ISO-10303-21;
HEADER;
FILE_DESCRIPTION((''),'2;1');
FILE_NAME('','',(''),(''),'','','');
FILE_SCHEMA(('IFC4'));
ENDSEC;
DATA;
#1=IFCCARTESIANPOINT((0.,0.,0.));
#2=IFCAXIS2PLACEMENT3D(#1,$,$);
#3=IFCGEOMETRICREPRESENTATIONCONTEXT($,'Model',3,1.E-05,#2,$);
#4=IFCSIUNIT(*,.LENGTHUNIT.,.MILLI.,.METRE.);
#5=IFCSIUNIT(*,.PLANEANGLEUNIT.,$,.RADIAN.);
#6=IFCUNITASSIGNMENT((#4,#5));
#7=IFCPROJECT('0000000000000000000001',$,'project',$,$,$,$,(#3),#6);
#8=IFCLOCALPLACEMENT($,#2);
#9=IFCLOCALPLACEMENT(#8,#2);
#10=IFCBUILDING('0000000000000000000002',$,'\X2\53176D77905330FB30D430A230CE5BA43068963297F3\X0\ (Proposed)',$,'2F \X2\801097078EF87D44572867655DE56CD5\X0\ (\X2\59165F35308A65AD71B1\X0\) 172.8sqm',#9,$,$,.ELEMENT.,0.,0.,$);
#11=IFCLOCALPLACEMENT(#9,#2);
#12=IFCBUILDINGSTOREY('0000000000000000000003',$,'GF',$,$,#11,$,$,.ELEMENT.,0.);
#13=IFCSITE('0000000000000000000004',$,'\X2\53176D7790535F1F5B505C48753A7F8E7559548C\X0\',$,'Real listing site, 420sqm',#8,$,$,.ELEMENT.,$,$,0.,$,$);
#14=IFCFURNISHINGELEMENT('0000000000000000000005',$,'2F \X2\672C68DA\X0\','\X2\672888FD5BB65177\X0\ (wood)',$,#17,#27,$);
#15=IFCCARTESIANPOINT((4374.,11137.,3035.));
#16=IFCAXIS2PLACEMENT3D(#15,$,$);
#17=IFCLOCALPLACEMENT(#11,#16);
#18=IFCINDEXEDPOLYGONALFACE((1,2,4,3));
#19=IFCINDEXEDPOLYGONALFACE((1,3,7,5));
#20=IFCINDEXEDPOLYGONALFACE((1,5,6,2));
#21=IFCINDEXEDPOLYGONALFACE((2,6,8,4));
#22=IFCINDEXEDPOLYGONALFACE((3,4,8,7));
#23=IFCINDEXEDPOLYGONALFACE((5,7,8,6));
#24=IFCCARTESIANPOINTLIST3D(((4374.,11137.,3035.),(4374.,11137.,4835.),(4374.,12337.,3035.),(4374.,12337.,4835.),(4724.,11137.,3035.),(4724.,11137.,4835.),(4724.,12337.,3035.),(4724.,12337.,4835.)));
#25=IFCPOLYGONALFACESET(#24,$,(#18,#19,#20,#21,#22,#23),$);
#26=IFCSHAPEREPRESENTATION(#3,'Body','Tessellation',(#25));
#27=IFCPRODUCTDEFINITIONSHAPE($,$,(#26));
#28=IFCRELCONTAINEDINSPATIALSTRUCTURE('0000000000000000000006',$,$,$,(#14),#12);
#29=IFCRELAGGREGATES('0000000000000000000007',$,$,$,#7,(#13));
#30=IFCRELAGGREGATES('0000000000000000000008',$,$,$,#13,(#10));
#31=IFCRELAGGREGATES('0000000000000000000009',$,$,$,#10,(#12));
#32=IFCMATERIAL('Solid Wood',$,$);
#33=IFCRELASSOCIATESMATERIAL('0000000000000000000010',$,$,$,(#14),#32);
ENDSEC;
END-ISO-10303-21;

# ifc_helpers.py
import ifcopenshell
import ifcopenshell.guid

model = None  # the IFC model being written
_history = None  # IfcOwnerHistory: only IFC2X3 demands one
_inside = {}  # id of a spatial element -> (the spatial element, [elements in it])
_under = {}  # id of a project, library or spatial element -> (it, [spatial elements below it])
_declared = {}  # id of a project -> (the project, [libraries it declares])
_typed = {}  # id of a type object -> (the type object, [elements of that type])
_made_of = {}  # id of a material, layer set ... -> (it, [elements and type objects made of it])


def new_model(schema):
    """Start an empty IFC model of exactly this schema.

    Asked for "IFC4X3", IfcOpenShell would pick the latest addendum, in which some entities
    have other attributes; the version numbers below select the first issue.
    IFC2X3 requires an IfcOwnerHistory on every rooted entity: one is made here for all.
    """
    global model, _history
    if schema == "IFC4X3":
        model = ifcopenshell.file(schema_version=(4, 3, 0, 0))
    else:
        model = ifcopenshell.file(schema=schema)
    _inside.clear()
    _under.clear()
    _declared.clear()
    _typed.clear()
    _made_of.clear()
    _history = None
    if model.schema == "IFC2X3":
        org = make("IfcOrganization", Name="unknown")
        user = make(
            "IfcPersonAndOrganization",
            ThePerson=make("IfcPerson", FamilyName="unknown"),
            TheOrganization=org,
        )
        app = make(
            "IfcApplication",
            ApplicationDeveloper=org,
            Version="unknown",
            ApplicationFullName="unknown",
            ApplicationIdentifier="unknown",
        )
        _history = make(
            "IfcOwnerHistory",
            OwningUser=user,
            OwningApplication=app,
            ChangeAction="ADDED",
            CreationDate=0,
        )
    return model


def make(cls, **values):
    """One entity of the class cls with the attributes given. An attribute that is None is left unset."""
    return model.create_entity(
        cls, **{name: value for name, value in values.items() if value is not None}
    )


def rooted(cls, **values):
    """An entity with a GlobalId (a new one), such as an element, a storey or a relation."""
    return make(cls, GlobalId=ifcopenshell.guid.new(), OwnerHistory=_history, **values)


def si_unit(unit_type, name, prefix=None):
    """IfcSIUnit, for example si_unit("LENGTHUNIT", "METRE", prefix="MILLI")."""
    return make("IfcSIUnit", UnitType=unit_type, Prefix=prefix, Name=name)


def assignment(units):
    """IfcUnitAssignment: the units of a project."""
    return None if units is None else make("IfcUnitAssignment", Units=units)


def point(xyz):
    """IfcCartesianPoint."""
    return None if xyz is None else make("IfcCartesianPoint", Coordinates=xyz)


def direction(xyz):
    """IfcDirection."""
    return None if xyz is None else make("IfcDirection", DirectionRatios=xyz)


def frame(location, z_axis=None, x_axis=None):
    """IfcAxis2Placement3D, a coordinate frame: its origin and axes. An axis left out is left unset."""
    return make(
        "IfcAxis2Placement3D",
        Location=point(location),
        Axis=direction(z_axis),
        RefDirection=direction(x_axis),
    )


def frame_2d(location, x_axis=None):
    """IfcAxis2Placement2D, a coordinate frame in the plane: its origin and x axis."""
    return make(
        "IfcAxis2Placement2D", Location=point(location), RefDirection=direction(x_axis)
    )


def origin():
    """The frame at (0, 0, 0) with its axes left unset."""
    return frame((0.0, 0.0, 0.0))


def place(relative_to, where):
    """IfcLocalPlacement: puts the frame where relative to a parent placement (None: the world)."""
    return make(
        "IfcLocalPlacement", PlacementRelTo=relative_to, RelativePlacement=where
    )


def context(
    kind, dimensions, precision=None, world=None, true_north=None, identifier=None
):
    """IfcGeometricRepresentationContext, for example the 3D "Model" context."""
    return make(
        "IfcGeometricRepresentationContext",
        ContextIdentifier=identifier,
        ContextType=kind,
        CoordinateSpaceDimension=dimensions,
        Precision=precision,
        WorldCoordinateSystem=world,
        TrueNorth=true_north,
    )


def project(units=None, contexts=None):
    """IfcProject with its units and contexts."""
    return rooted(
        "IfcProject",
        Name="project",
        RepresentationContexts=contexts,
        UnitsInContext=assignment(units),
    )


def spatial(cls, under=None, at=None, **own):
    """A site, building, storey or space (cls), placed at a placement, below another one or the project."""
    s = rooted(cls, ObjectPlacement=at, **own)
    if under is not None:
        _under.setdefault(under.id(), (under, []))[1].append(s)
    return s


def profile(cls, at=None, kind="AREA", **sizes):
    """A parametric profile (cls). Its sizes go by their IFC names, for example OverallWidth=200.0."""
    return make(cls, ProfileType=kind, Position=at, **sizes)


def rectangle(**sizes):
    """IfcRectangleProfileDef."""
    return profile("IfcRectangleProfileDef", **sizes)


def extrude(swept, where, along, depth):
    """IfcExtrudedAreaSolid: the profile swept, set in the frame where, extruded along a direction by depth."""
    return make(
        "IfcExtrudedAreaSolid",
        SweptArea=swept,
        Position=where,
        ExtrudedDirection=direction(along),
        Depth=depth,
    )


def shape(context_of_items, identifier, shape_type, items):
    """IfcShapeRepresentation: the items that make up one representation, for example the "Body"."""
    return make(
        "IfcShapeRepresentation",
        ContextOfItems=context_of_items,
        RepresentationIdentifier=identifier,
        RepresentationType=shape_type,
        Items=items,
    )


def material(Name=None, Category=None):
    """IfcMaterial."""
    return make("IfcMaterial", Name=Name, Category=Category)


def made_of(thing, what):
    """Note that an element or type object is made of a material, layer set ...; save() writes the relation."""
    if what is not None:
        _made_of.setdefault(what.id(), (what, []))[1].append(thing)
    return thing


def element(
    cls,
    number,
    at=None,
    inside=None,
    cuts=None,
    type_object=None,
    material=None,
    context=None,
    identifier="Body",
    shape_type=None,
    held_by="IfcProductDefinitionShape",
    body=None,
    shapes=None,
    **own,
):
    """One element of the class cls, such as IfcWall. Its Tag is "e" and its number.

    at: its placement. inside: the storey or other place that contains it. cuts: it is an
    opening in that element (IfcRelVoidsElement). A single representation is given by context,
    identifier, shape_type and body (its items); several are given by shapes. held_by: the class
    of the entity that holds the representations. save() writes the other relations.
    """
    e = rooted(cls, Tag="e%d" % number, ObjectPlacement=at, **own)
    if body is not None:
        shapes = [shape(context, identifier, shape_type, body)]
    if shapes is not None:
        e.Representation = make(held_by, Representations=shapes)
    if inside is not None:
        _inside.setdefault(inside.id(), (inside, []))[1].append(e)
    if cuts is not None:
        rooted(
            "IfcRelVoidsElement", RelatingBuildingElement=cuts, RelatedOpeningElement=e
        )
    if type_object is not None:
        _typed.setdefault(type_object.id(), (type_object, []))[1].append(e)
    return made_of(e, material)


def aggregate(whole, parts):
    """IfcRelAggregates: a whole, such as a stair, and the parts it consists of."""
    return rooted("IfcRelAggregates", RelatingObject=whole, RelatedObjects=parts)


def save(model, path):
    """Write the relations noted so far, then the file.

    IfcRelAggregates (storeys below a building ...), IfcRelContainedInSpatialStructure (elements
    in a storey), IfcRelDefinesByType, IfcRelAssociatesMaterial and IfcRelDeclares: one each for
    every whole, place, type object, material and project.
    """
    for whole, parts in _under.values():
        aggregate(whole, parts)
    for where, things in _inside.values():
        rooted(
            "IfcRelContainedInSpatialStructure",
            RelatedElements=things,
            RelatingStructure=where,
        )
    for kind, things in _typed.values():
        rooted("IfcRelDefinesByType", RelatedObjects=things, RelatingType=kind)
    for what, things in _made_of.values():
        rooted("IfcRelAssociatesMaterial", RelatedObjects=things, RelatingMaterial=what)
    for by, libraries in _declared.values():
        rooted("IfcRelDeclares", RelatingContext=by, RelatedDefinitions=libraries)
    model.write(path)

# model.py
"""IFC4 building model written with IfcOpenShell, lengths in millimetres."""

from ifc_helpers import new_model, si_unit, frame, frame_2d, origin, place, context, project, spatial, rectangle, extrude, material, element, save


model = new_model("IFC4")

# Units and contexts
model_context = context("Model", 3, precision=1e-05, world=origin())
ifc_project = project(units=[si_unit("LENGTHUNIT", "METRE", prefix="MILLI"), si_unit("PLANEANGLEUNIT", "RADIAN")], contexts=[model_context])

# Site, building, storey
site_placement = place(None, origin())
site = spatial("IfcSite", under=ifc_project, at=site_placement, Name="北海道弟子屈町美留和", ObjectType="Real listing site, 420sqm", CompositionType="ELEMENT", RefElevation=0.0)
building_placement = place(site_placement, origin())
building = spatial("IfcBuilding", under=site, at=building_placement, Name="北海道・ピアノ室と防音 (Proposed)", ObjectType="2F 耐震軸組在来工法 (外張り断熱) 172.8sqm", CompositionType="ELEMENT", ElevationOfRefHeight=0.0, ElevationOfTerrain=0.0)
storey_placement = place(building_placement, origin())
storey = spatial("IfcBuildingStorey", under=building, at=storey_placement, Name="GF", CompositionType="ELEMENT", Elevation=0.0)

# Shared definitions
ifc_material_1 = material(Name="Solid Wood")

# Furnishing element
furnishing_1_placement = place(storey_placement, frame((4374.0, 11137.0, 3035.0)))
element("IfcFurnishingElement", 1, at=furnishing_1_placement, inside=storey, material=ifc_material_1, Name="2F 本棚", Description="木製家具 (wood)", context=model_context, shape_type="SweptSolid", body=[
    extrude(rectangle(XDim=350.0, YDim=1200.0, at=frame_2d((175.0, 600.0))), frame((4374.0, 11137.0, 3035.0)), (0.0, 0.0, 1.0), 1800.0),
])

save(model, "model.ifc")
